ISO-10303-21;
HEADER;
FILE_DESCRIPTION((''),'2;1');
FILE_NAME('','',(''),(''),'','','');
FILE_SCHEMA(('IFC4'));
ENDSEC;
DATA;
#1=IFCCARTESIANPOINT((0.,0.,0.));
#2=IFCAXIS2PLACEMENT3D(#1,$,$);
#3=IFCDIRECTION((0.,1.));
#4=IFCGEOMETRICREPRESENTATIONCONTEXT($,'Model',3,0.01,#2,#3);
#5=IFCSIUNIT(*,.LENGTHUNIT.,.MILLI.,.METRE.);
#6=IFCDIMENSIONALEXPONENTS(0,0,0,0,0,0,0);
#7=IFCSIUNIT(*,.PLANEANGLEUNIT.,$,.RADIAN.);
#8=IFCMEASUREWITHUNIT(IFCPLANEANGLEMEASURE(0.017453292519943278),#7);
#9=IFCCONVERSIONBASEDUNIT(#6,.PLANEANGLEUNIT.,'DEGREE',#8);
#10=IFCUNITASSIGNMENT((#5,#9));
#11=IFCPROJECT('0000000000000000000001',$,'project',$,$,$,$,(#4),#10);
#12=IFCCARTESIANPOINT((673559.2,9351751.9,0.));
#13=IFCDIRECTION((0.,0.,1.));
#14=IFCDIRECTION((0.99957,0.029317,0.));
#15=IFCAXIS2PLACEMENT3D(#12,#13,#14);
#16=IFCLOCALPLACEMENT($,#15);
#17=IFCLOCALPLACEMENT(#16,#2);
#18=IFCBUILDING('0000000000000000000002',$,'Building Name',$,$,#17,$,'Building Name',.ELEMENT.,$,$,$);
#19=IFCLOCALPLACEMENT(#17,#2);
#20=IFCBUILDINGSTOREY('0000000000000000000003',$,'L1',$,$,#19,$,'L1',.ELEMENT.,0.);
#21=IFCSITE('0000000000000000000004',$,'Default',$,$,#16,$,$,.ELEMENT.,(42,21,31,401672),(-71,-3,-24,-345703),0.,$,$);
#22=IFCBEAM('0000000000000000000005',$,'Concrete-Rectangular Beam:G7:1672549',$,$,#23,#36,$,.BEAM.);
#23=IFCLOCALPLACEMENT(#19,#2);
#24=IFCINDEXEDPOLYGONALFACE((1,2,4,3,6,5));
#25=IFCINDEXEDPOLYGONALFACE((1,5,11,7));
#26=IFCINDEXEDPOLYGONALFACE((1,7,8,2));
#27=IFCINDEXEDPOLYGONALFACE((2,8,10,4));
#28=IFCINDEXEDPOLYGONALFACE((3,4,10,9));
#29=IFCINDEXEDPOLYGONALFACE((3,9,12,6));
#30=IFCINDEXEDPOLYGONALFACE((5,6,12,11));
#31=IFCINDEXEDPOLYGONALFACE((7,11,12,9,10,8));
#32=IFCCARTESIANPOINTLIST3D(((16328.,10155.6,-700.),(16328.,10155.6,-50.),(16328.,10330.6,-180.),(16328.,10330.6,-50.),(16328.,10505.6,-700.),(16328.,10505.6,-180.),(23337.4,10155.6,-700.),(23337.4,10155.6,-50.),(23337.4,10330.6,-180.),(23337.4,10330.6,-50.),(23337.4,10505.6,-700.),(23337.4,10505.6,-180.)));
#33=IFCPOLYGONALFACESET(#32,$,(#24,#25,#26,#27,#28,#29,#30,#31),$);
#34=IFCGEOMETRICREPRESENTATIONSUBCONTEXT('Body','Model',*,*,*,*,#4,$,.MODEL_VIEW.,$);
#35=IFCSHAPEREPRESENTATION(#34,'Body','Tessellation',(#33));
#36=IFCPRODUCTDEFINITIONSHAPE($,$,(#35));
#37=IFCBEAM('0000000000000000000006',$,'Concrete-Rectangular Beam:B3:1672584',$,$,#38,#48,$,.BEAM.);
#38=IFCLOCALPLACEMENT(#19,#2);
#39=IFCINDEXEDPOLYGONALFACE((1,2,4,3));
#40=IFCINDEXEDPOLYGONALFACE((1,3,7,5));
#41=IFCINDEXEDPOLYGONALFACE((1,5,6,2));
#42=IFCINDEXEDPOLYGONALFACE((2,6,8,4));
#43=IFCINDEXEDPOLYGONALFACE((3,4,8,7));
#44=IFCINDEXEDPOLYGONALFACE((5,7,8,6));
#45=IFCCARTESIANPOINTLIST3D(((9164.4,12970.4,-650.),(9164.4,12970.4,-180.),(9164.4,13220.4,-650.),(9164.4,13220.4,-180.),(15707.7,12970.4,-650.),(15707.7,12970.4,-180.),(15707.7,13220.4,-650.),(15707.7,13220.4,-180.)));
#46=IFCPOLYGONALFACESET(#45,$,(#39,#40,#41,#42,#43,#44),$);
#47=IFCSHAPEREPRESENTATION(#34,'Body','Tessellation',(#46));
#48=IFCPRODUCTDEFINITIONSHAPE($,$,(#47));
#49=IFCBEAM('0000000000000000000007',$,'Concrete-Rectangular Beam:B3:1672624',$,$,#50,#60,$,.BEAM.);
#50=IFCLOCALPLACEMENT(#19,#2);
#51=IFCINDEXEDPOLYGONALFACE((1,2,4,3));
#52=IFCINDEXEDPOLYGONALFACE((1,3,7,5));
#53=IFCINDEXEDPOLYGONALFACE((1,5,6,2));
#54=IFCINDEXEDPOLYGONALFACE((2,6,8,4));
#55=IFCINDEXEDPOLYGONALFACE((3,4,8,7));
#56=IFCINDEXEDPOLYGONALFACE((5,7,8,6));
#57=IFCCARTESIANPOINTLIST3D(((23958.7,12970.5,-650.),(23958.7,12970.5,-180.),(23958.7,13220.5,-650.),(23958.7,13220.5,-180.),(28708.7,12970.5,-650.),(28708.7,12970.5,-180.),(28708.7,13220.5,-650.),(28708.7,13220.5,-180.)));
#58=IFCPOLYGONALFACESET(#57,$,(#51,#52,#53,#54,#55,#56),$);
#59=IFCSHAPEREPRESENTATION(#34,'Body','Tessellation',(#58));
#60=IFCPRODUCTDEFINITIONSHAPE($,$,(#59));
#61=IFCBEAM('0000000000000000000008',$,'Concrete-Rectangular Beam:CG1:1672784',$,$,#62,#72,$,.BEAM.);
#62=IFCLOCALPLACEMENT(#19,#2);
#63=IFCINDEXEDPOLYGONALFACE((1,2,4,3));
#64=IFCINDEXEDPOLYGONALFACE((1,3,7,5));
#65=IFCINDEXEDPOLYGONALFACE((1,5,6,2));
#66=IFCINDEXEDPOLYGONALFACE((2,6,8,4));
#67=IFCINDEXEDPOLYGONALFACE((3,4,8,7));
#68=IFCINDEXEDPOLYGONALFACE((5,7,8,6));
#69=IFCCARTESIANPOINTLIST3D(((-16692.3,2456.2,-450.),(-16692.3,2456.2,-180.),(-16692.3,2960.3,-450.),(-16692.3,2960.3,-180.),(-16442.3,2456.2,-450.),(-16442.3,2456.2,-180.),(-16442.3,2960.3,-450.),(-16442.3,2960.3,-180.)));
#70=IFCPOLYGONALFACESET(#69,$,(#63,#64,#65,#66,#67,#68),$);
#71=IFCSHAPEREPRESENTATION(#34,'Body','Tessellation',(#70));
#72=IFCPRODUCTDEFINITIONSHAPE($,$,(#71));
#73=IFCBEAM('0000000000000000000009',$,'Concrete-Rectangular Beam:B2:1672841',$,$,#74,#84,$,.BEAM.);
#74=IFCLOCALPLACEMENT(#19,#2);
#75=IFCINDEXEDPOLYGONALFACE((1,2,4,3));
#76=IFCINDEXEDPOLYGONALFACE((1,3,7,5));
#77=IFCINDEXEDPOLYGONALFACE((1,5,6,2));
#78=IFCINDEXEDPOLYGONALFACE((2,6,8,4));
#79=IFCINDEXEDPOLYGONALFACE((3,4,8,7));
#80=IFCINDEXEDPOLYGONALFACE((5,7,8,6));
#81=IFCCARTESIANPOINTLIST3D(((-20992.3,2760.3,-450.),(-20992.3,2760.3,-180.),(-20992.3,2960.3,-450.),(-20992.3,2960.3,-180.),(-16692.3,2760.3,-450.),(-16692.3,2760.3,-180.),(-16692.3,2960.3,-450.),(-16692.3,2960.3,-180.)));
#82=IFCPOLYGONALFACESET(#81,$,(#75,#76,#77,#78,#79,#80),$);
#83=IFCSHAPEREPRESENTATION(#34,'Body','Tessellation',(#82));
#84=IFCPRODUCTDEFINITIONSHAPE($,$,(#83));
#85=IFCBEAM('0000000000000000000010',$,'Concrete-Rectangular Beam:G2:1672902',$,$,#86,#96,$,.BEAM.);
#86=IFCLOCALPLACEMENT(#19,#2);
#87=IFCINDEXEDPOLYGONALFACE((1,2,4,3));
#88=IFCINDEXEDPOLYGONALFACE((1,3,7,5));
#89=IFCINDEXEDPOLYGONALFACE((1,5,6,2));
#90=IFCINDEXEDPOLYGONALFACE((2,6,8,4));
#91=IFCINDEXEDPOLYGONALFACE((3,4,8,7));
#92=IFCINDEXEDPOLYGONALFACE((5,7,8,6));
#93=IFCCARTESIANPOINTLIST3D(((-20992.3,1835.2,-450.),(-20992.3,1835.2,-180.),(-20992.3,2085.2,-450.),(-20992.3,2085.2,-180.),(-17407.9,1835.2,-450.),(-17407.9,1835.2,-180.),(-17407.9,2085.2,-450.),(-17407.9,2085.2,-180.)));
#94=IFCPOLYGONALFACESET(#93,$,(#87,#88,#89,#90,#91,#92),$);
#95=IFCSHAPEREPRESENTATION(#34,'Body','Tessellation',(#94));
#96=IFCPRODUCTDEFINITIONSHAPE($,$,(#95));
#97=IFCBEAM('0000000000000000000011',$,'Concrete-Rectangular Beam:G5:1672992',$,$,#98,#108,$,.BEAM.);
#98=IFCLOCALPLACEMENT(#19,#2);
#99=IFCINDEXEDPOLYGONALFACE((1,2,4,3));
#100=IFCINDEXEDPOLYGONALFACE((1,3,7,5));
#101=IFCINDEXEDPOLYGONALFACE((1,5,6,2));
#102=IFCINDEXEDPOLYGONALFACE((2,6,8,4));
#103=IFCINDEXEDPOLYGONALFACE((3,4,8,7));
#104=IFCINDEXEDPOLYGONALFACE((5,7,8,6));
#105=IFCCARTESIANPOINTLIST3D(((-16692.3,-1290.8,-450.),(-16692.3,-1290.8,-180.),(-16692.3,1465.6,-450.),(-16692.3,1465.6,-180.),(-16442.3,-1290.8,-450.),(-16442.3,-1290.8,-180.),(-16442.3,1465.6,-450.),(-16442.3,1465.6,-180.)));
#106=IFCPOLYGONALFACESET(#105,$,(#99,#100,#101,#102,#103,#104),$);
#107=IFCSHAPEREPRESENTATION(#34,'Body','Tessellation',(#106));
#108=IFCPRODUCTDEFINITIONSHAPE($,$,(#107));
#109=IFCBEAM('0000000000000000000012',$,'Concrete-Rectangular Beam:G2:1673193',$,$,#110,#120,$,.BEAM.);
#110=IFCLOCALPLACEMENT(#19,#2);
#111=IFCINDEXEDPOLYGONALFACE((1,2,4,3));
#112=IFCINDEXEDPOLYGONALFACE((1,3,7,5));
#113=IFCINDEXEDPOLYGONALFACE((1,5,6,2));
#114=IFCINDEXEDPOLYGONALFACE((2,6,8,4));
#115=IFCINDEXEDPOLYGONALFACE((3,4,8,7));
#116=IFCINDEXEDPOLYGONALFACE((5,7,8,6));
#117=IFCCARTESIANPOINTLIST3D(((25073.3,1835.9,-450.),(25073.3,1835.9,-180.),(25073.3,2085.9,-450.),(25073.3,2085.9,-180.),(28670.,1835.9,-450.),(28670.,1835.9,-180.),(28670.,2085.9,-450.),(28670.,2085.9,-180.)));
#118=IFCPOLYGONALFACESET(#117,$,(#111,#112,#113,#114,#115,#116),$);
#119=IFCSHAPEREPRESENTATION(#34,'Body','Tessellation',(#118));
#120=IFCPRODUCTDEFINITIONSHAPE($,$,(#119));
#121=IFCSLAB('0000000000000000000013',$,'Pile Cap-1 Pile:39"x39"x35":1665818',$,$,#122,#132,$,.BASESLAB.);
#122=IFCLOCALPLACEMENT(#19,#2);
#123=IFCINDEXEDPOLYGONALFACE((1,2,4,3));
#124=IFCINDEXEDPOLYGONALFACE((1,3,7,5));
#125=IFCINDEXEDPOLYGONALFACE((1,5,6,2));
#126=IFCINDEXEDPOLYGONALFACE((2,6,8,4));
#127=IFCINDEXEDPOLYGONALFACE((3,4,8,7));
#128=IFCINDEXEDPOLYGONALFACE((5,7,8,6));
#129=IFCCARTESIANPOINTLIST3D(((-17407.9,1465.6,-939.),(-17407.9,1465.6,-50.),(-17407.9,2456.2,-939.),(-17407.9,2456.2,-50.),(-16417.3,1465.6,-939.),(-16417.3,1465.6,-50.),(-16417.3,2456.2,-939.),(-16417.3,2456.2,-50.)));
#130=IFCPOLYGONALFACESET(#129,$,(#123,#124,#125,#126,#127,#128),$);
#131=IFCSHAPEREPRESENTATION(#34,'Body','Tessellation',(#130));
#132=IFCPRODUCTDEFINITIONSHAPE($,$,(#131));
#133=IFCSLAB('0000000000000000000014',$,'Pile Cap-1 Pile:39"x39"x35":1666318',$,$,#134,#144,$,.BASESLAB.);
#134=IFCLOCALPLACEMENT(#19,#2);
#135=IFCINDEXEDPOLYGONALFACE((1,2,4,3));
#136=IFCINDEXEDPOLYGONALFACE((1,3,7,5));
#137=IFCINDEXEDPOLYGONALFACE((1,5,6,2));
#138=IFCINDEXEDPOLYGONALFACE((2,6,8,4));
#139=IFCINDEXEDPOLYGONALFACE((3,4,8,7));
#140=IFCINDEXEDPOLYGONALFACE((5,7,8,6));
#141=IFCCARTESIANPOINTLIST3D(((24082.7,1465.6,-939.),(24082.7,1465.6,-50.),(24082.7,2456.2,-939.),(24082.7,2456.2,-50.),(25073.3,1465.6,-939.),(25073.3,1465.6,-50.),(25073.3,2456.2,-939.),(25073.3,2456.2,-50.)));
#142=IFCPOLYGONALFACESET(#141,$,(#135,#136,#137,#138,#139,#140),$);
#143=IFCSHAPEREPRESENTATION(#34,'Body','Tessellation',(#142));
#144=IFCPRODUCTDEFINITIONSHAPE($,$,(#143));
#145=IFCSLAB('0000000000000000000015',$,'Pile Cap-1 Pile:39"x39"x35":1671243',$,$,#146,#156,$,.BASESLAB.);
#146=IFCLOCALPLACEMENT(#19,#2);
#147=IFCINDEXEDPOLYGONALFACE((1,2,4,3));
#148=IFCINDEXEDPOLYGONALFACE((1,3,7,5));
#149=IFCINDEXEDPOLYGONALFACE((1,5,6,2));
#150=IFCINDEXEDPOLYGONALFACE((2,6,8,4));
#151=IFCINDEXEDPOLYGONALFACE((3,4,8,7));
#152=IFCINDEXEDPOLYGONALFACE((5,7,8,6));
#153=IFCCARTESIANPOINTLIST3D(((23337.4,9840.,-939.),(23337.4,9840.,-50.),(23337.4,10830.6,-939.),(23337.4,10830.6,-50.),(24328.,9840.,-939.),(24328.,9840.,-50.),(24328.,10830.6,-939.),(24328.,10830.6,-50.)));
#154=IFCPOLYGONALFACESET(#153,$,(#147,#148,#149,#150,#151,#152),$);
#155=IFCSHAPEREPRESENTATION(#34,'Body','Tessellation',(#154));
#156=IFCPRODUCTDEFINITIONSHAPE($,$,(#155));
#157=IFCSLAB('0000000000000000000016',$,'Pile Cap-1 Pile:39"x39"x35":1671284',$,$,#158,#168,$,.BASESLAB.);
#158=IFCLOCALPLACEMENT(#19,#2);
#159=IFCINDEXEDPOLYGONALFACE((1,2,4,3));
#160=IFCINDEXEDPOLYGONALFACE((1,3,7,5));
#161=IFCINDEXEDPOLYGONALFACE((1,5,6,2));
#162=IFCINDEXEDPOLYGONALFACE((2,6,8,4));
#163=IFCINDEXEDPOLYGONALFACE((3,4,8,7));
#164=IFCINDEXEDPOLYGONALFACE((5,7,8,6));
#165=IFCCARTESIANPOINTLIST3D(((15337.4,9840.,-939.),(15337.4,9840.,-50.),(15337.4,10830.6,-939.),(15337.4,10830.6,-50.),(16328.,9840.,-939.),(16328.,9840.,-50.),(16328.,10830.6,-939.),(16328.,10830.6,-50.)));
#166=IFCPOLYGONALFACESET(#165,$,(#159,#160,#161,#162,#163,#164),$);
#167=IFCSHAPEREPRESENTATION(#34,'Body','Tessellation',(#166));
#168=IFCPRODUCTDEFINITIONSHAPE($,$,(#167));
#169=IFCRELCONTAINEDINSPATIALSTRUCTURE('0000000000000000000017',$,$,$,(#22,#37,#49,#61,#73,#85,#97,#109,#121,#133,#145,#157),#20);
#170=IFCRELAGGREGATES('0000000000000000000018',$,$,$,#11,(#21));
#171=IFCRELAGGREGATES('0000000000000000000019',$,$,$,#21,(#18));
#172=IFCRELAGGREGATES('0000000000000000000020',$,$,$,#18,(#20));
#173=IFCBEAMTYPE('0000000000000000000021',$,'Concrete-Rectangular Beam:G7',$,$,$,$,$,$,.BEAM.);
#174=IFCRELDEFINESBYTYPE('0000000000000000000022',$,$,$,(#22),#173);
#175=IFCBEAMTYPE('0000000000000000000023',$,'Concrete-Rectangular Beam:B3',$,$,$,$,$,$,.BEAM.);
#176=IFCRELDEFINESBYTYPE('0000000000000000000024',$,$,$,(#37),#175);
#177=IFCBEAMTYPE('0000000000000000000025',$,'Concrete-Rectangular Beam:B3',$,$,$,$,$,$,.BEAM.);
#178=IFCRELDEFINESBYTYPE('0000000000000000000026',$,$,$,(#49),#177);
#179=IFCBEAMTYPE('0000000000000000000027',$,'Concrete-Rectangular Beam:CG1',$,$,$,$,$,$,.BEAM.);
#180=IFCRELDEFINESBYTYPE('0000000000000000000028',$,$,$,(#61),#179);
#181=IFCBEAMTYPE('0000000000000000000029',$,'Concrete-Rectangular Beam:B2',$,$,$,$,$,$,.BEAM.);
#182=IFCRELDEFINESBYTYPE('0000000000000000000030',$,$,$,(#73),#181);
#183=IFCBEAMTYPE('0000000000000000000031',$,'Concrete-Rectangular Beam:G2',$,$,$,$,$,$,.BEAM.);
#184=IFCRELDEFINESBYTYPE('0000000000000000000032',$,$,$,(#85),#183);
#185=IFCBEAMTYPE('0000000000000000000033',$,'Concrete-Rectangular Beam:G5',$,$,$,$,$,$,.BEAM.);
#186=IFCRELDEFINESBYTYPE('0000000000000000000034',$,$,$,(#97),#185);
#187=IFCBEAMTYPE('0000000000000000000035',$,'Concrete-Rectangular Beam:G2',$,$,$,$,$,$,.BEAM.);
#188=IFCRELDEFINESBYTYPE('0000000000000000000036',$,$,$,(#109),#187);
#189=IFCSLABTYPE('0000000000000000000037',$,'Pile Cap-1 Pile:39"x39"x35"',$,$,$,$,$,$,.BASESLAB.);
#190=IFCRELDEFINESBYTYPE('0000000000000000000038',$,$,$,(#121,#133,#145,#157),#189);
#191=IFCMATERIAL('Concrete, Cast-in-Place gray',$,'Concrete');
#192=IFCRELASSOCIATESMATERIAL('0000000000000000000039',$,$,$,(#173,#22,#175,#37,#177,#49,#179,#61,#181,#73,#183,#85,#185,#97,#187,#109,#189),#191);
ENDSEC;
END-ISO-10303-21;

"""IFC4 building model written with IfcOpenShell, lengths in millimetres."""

from ifc_helpers import new_model, entity, si_unit, converted_unit, direction, frame, origin, place, context, subcontext, project, spatial, indexed_curve, outline, extrude, source, transform, mapped, material, type_object, type_shapes, element, save


model = new_model("IFC4")

# Units and contexts
model_context = context("Model", 3, precision=0.01, world=origin(), true_north=direction((0.0, 1.0)))
body_context = subcontext(model_context, "Body", "Model", "MODEL_VIEW")
ifc_project = project(units=[si_unit("LENGTHUNIT", "METRE", prefix="MILLI"), converted_unit("PLANEANGLEUNIT", "DEGREE", entity("IfcPlaneAngleMeasure", 0.017453292519943278), si_unit("PLANEANGLEUNIT", "RADIAN"), dimensions=[0, 0, 0, 0, 0, 0, 0])], contexts=[model_context])

# Site, building, storey
site_placement = place(None, frame((673559.2, 9351751.9, 0.0), z_axis=(0.0, 0.0, 1.0), x_axis=(0.99957, 0.029317, 0.0)))
site = spatial("IfcSite", under=ifc_project, at=site_placement, Name="Default", CompositionType="ELEMENT", RefLatitude=(42, 21, 31, 401672), RefLongitude=(-71, -3, -24, -345703), RefElevation=0.0)
building_placement = place(site_placement, origin())
building = spatial("IfcBuilding", under=site, at=building_placement, Name="Building Name", LongName="Building Name", CompositionType="ELEMENT")
storey_placement = place(building_placement, origin())
storey = spatial("IfcBuildingStorey", under=building, at=storey_placement, Name="L1", LongName="L1", CompositionType="ELEMENT", Elevation=0.0)

# Beams
ifc_material_1 = material(Name="Concrete, Cast-in-Place gray", Category="Concrete")
beam_type_1 = type_object("IfcBeamType", Name="Concrete-Rectangular Beam:G7", PredefinedType="BEAM", material=ifc_material_1)
shared_shape_1 = source(origin(), body_context, "Body", "SweptSolid", [
    extrude(outline(indexed_curve([(-130.0, -175.0), (390.0, -175.0), (390.0, 175.0), (-260.0, 175.0), (-260.0, 0.0), (-130.0, 0.0), (-130.0, -175.0)], self_intersect=False)), frame((23337.4, 10330.6, -310.0), z_axis=(-1.0, 0.0, 0.0), x_axis=(0.0, 0.0, -1.0)), (0.0, 0.0, 1.0), 7009.4),
])
type_shapes(beam_type_1, [shared_shape_1])
beam_1_placement = place(storey_placement, origin())
element("IfcBeam", 1, at=beam_1_placement, inside=storey, type_object=beam_type_1, material=ifc_material_1, Name="Concrete-Rectangular Beam:G7:1672549", PredefinedType="BEAM", context=body_context, shape_type="MappedRepresentation", body=[
    mapped(shared_shape_1, transform((0.0, 0.0, 0.0), scale=1.0)),
])
beam_type_2 = type_object("IfcBeamType", Name="Concrete-Rectangular Beam:B3", PredefinedType="BEAM", material=ifc_material_1)
shared_shape_2 = source(origin(), body_context, "Body", "SweptSolid", [
    extrude(outline(indexed_curve([(-235.0, -125.0), (235.0, -125.0), (235.0, 125.0), (-235.0, 125.0), (-235.0, -125.0)], self_intersect=False)), frame((9164.4, 13095.4, -415.0), z_axis=(1.0, 0.0, 0.0), x_axis=(0.0, 0.0, -1.0)), (0.0, 0.0, 1.0), 6543.3),
])
type_shapes(beam_type_2, [shared_shape_2])
beam_2_placement = place(storey_placement, origin())
element("IfcBeam", 2, at=beam_2_placement, inside=storey, type_object=beam_type_2, material=ifc_material_1, Name="Concrete-Rectangular Beam:B3:1672584", PredefinedType="BEAM", context=body_context, shape_type="MappedRepresentation", body=[
    mapped(shared_shape_2, transform((0.0, 0.0, 0.0), scale=1.0)),
])
beam_type_3 = type_object("IfcBeamType", Name="Concrete-Rectangular Beam:B3", PredefinedType="BEAM", material=ifc_material_1)
shared_shape_3 = source(origin(), body_context, "Body", "SweptSolid", [
    extrude(outline(indexed_curve([(-235.0, -125.0), (235.0, -125.0), (235.0, 125.0), (-235.0, 125.0), (-235.0, -125.0)], self_intersect=False)), frame((23958.7, 13095.5, -415.0), z_axis=(1.0, 0.0, 0.0), x_axis=(0.0, 0.0, -1.0)), (0.0, 0.0, 1.0), 4750.0),
])
type_shapes(beam_type_3, [shared_shape_3])
beam_3_placement = place(storey_placement, origin())
element("IfcBeam", 3, at=beam_3_placement, inside=storey, type_object=beam_type_3, material=ifc_material_1, Name="Concrete-Rectangular Beam:B3:1672624", PredefinedType="BEAM", context=body_context, shape_type="MappedRepresentation", body=[
    mapped(shared_shape_3, transform((0.0, 0.0, 0.0), scale=1.0)),
])
beam_type_4 = type_object("IfcBeamType", Name="Concrete-Rectangular Beam:CG1", PredefinedType="BEAM", material=ifc_material_1)
shared_shape_4 = source(origin(), body_context, "Body", "SweptSolid", [
    extrude(outline(indexed_curve([(-125.0, -135.0), (125.0, -135.0), (125.0, 135.0), (-125.0, 135.0), (-125.0, -135.0)], self_intersect=False)), frame((-16567.3, 2456.2, -315.0), z_axis=(0.0, 1.0, 0.0), x_axis=(-1.0, 0.0, 0.0)), (0.0, 0.0, 1.0), 504.1),
])
type_shapes(beam_type_4, [shared_shape_4])
beam_4_placement = place(storey_placement, origin())
element("IfcBeam", 4, at=beam_4_placement, inside=storey, type_object=beam_type_4, material=ifc_material_1, Name="Concrete-Rectangular Beam:CG1:1672784", PredefinedType="BEAM", context=body_context, shape_type="MappedRepresentation", body=[
    mapped(shared_shape_4, transform((0.0, 0.0, 0.0), scale=1.0)),
])
beam_type_5 = type_object("IfcBeamType", Name="Concrete-Rectangular Beam:B2", PredefinedType="BEAM", material=ifc_material_1)
shared_shape_5 = source(origin(), body_context, "Body", "SweptSolid", [
    extrude(outline(indexed_curve([(-135.0, -100.0), (135.0, -100.0), (135.0, 100.0), (-135.0, 100.0), (-135.0, -100.0)], self_intersect=False)), frame((-20992.3, 2860.3, -315.0), z_axis=(1.0, 0.0, 0.0), x_axis=(0.0, 0.0, -1.0)), (0.0, 0.0, 1.0), 4300.0),
])
type_shapes(beam_type_5, [shared_shape_5])
beam_5_placement = place(storey_placement, origin())
element("IfcBeam", 5, at=beam_5_placement, inside=storey, type_object=beam_type_5, material=ifc_material_1, Name="Concrete-Rectangular Beam:B2:1672841", PredefinedType="BEAM", context=body_context, shape_type="MappedRepresentation", body=[
    mapped(shared_shape_5, transform((0.0, 0.0, 0.0), scale=1.0)),
])
beam_type_6 = type_object("IfcBeamType", Name="Concrete-Rectangular Beam:G2", PredefinedType="BEAM", material=ifc_material_1)
shared_shape_6 = source(origin(), body_context, "Body", "SweptSolid", [
    extrude(outline(indexed_curve([(-135.0, -125.0), (135.0, -125.0), (135.0, 125.0), (-135.0, 125.0), (-135.0, -125.0)], self_intersect=False)), frame((-20992.3, 1960.2, -315.0), z_axis=(1.0, 0.0, 0.0), x_axis=(0.0, 0.0, -1.0)), (0.0, 0.0, 1.0), 3584.4),
])
type_shapes(beam_type_6, [shared_shape_6])
beam_6_placement = place(storey_placement, origin())
element("IfcBeam", 6, at=beam_6_placement, inside=storey, type_object=beam_type_6, material=ifc_material_1, Name="Concrete-Rectangular Beam:G2:1672902", PredefinedType="BEAM", context=body_context, shape_type="MappedRepresentation", body=[
    mapped(shared_shape_6, transform((0.0, 0.0, 0.0), scale=1.0)),
])
beam_type_7 = type_object("IfcBeamType", Name="Concrete-Rectangular Beam:G5", PredefinedType="BEAM", material=ifc_material_1)
shared_shape_7 = source(origin(), body_context, "Body", "SweptSolid", [
    extrude(outline(indexed_curve([(-125.0, -135.0), (125.0, -135.0), (125.0, 135.0), (-125.0, 135.0), (-125.0, -135.0)], self_intersect=False)), frame((-16567.3, 1465.6, -315.0), z_axis=(0.0, -1.0, 0.0), x_axis=(-1.0, 0.0, 0.0)), (0.0, 0.0, 1.0), 2756.4),
])
type_shapes(beam_type_7, [shared_shape_7])
beam_7_placement = place(storey_placement, origin())
element("IfcBeam", 7, at=beam_7_placement, inside=storey, type_object=beam_type_7, material=ifc_material_1, Name="Concrete-Rectangular Beam:G5:1672992", PredefinedType="BEAM", context=body_context, shape_type="MappedRepresentation", body=[
    mapped(shared_shape_7, transform((0.0, 0.0, 0.0), scale=1.0)),
])
beam_type_8 = type_object("IfcBeamType", Name="Concrete-Rectangular Beam:G2", PredefinedType="BEAM", material=ifc_material_1)
shared_shape_8 = source(origin(), body_context, "Body", "SweptSolid", [
    extrude(outline(indexed_curve([(-135.0, -125.0), (135.0, -125.0), (135.0, 125.0), (-135.0, 125.0), (-135.0, -125.0)], self_intersect=False)), frame((28670.0, 1960.9, -315.0), z_axis=(-1.0, 0.0, 0.0), x_axis=(0.0, 0.0, -1.0)), (0.0, 0.0, 1.0), 3596.7),
])
type_shapes(beam_type_8, [shared_shape_8])
beam_8_placement = place(storey_placement, origin())
element("IfcBeam", 8, at=beam_8_placement, inside=storey, type_object=beam_type_8, material=ifc_material_1, Name="Concrete-Rectangular Beam:G2:1673193", PredefinedType="BEAM", context=body_context, shape_type="MappedRepresentation", body=[
    mapped(shared_shape_8, transform((0.0, 0.0, 0.0), scale=1.0)),
])

# Slabs
slab_type_1 = type_object("IfcSlabType", Name="Pile Cap-1 Pile:39\"x39\"x35\"", PredefinedType="BASESLAB", material=ifc_material_1)
slab_1_placement = place(storey_placement, origin())
element("IfcSlab", 9, at=slab_1_placement, inside=storey, type_object=slab_type_1, Name="Pile Cap-1 Pile:39\"x39\"x35\":1665818", PredefinedType="BASESLAB", context=body_context, shape_type="SweptSolid", body=[
    extrude(outline(indexed_curve([(-495.3, -495.3), (495.3, -495.3), (495.3, 495.3), (-495.3, 495.3), (-495.3, -495.3)], self_intersect=False)), frame((-16912.6, 1960.9, -939.0)), (0.0, 0.0, 1.0), 889.0),
])
slab_2_placement = place(storey_placement, origin())
element("IfcSlab", 10, at=slab_2_placement, inside=storey, type_object=slab_type_1, Name="Pile Cap-1 Pile:39\"x39\"x35\":1666318", PredefinedType="BASESLAB", context=body_context, shape_type="SweptSolid", body=[
    extrude(outline(indexed_curve([(-495.3, -495.3), (495.3, -495.3), (495.3, 495.3), (-495.3, 495.3), (-495.3, -495.3)], self_intersect=False)), frame((24578.0, 1960.9, -939.0)), (0.0, 0.0, 1.0), 889.0),
])
slab_3_placement = place(storey_placement, origin())
element("IfcSlab", 11, at=slab_3_placement, inside=storey, type_object=slab_type_1, Name="Pile Cap-1 Pile:39\"x39\"x35\":1671243", PredefinedType="BASESLAB", context=body_context, shape_type="SweptSolid", body=[
    extrude(outline(indexed_curve([(-495.3, -495.3), (495.3, -495.3), (495.3, 495.3), (-495.3, 495.3), (-495.3, -495.3)], self_intersect=False)), frame((23832.7, 10335.3, -939.0)), (0.0, 0.0, 1.0), 889.0),
])
slab_4_placement = place(storey_placement, origin())
element("IfcSlab", 12, at=slab_4_placement, inside=storey, type_object=slab_type_1, Name="Pile Cap-1 Pile:39\"x39\"x35\":1671284", PredefinedType="BASESLAB", context=body_context, shape_type="SweptSolid", body=[
    extrude(outline(indexed_curve([(-495.3, -495.3), (495.3, -495.3), (495.3, 495.3), (-495.3, 495.3), (-495.3, -495.3)], self_intersect=False)), frame((15832.7, 10335.3, -939.0)), (0.0, 0.0, 1.0), 889.0),
])

save(model, "model.ifc")
